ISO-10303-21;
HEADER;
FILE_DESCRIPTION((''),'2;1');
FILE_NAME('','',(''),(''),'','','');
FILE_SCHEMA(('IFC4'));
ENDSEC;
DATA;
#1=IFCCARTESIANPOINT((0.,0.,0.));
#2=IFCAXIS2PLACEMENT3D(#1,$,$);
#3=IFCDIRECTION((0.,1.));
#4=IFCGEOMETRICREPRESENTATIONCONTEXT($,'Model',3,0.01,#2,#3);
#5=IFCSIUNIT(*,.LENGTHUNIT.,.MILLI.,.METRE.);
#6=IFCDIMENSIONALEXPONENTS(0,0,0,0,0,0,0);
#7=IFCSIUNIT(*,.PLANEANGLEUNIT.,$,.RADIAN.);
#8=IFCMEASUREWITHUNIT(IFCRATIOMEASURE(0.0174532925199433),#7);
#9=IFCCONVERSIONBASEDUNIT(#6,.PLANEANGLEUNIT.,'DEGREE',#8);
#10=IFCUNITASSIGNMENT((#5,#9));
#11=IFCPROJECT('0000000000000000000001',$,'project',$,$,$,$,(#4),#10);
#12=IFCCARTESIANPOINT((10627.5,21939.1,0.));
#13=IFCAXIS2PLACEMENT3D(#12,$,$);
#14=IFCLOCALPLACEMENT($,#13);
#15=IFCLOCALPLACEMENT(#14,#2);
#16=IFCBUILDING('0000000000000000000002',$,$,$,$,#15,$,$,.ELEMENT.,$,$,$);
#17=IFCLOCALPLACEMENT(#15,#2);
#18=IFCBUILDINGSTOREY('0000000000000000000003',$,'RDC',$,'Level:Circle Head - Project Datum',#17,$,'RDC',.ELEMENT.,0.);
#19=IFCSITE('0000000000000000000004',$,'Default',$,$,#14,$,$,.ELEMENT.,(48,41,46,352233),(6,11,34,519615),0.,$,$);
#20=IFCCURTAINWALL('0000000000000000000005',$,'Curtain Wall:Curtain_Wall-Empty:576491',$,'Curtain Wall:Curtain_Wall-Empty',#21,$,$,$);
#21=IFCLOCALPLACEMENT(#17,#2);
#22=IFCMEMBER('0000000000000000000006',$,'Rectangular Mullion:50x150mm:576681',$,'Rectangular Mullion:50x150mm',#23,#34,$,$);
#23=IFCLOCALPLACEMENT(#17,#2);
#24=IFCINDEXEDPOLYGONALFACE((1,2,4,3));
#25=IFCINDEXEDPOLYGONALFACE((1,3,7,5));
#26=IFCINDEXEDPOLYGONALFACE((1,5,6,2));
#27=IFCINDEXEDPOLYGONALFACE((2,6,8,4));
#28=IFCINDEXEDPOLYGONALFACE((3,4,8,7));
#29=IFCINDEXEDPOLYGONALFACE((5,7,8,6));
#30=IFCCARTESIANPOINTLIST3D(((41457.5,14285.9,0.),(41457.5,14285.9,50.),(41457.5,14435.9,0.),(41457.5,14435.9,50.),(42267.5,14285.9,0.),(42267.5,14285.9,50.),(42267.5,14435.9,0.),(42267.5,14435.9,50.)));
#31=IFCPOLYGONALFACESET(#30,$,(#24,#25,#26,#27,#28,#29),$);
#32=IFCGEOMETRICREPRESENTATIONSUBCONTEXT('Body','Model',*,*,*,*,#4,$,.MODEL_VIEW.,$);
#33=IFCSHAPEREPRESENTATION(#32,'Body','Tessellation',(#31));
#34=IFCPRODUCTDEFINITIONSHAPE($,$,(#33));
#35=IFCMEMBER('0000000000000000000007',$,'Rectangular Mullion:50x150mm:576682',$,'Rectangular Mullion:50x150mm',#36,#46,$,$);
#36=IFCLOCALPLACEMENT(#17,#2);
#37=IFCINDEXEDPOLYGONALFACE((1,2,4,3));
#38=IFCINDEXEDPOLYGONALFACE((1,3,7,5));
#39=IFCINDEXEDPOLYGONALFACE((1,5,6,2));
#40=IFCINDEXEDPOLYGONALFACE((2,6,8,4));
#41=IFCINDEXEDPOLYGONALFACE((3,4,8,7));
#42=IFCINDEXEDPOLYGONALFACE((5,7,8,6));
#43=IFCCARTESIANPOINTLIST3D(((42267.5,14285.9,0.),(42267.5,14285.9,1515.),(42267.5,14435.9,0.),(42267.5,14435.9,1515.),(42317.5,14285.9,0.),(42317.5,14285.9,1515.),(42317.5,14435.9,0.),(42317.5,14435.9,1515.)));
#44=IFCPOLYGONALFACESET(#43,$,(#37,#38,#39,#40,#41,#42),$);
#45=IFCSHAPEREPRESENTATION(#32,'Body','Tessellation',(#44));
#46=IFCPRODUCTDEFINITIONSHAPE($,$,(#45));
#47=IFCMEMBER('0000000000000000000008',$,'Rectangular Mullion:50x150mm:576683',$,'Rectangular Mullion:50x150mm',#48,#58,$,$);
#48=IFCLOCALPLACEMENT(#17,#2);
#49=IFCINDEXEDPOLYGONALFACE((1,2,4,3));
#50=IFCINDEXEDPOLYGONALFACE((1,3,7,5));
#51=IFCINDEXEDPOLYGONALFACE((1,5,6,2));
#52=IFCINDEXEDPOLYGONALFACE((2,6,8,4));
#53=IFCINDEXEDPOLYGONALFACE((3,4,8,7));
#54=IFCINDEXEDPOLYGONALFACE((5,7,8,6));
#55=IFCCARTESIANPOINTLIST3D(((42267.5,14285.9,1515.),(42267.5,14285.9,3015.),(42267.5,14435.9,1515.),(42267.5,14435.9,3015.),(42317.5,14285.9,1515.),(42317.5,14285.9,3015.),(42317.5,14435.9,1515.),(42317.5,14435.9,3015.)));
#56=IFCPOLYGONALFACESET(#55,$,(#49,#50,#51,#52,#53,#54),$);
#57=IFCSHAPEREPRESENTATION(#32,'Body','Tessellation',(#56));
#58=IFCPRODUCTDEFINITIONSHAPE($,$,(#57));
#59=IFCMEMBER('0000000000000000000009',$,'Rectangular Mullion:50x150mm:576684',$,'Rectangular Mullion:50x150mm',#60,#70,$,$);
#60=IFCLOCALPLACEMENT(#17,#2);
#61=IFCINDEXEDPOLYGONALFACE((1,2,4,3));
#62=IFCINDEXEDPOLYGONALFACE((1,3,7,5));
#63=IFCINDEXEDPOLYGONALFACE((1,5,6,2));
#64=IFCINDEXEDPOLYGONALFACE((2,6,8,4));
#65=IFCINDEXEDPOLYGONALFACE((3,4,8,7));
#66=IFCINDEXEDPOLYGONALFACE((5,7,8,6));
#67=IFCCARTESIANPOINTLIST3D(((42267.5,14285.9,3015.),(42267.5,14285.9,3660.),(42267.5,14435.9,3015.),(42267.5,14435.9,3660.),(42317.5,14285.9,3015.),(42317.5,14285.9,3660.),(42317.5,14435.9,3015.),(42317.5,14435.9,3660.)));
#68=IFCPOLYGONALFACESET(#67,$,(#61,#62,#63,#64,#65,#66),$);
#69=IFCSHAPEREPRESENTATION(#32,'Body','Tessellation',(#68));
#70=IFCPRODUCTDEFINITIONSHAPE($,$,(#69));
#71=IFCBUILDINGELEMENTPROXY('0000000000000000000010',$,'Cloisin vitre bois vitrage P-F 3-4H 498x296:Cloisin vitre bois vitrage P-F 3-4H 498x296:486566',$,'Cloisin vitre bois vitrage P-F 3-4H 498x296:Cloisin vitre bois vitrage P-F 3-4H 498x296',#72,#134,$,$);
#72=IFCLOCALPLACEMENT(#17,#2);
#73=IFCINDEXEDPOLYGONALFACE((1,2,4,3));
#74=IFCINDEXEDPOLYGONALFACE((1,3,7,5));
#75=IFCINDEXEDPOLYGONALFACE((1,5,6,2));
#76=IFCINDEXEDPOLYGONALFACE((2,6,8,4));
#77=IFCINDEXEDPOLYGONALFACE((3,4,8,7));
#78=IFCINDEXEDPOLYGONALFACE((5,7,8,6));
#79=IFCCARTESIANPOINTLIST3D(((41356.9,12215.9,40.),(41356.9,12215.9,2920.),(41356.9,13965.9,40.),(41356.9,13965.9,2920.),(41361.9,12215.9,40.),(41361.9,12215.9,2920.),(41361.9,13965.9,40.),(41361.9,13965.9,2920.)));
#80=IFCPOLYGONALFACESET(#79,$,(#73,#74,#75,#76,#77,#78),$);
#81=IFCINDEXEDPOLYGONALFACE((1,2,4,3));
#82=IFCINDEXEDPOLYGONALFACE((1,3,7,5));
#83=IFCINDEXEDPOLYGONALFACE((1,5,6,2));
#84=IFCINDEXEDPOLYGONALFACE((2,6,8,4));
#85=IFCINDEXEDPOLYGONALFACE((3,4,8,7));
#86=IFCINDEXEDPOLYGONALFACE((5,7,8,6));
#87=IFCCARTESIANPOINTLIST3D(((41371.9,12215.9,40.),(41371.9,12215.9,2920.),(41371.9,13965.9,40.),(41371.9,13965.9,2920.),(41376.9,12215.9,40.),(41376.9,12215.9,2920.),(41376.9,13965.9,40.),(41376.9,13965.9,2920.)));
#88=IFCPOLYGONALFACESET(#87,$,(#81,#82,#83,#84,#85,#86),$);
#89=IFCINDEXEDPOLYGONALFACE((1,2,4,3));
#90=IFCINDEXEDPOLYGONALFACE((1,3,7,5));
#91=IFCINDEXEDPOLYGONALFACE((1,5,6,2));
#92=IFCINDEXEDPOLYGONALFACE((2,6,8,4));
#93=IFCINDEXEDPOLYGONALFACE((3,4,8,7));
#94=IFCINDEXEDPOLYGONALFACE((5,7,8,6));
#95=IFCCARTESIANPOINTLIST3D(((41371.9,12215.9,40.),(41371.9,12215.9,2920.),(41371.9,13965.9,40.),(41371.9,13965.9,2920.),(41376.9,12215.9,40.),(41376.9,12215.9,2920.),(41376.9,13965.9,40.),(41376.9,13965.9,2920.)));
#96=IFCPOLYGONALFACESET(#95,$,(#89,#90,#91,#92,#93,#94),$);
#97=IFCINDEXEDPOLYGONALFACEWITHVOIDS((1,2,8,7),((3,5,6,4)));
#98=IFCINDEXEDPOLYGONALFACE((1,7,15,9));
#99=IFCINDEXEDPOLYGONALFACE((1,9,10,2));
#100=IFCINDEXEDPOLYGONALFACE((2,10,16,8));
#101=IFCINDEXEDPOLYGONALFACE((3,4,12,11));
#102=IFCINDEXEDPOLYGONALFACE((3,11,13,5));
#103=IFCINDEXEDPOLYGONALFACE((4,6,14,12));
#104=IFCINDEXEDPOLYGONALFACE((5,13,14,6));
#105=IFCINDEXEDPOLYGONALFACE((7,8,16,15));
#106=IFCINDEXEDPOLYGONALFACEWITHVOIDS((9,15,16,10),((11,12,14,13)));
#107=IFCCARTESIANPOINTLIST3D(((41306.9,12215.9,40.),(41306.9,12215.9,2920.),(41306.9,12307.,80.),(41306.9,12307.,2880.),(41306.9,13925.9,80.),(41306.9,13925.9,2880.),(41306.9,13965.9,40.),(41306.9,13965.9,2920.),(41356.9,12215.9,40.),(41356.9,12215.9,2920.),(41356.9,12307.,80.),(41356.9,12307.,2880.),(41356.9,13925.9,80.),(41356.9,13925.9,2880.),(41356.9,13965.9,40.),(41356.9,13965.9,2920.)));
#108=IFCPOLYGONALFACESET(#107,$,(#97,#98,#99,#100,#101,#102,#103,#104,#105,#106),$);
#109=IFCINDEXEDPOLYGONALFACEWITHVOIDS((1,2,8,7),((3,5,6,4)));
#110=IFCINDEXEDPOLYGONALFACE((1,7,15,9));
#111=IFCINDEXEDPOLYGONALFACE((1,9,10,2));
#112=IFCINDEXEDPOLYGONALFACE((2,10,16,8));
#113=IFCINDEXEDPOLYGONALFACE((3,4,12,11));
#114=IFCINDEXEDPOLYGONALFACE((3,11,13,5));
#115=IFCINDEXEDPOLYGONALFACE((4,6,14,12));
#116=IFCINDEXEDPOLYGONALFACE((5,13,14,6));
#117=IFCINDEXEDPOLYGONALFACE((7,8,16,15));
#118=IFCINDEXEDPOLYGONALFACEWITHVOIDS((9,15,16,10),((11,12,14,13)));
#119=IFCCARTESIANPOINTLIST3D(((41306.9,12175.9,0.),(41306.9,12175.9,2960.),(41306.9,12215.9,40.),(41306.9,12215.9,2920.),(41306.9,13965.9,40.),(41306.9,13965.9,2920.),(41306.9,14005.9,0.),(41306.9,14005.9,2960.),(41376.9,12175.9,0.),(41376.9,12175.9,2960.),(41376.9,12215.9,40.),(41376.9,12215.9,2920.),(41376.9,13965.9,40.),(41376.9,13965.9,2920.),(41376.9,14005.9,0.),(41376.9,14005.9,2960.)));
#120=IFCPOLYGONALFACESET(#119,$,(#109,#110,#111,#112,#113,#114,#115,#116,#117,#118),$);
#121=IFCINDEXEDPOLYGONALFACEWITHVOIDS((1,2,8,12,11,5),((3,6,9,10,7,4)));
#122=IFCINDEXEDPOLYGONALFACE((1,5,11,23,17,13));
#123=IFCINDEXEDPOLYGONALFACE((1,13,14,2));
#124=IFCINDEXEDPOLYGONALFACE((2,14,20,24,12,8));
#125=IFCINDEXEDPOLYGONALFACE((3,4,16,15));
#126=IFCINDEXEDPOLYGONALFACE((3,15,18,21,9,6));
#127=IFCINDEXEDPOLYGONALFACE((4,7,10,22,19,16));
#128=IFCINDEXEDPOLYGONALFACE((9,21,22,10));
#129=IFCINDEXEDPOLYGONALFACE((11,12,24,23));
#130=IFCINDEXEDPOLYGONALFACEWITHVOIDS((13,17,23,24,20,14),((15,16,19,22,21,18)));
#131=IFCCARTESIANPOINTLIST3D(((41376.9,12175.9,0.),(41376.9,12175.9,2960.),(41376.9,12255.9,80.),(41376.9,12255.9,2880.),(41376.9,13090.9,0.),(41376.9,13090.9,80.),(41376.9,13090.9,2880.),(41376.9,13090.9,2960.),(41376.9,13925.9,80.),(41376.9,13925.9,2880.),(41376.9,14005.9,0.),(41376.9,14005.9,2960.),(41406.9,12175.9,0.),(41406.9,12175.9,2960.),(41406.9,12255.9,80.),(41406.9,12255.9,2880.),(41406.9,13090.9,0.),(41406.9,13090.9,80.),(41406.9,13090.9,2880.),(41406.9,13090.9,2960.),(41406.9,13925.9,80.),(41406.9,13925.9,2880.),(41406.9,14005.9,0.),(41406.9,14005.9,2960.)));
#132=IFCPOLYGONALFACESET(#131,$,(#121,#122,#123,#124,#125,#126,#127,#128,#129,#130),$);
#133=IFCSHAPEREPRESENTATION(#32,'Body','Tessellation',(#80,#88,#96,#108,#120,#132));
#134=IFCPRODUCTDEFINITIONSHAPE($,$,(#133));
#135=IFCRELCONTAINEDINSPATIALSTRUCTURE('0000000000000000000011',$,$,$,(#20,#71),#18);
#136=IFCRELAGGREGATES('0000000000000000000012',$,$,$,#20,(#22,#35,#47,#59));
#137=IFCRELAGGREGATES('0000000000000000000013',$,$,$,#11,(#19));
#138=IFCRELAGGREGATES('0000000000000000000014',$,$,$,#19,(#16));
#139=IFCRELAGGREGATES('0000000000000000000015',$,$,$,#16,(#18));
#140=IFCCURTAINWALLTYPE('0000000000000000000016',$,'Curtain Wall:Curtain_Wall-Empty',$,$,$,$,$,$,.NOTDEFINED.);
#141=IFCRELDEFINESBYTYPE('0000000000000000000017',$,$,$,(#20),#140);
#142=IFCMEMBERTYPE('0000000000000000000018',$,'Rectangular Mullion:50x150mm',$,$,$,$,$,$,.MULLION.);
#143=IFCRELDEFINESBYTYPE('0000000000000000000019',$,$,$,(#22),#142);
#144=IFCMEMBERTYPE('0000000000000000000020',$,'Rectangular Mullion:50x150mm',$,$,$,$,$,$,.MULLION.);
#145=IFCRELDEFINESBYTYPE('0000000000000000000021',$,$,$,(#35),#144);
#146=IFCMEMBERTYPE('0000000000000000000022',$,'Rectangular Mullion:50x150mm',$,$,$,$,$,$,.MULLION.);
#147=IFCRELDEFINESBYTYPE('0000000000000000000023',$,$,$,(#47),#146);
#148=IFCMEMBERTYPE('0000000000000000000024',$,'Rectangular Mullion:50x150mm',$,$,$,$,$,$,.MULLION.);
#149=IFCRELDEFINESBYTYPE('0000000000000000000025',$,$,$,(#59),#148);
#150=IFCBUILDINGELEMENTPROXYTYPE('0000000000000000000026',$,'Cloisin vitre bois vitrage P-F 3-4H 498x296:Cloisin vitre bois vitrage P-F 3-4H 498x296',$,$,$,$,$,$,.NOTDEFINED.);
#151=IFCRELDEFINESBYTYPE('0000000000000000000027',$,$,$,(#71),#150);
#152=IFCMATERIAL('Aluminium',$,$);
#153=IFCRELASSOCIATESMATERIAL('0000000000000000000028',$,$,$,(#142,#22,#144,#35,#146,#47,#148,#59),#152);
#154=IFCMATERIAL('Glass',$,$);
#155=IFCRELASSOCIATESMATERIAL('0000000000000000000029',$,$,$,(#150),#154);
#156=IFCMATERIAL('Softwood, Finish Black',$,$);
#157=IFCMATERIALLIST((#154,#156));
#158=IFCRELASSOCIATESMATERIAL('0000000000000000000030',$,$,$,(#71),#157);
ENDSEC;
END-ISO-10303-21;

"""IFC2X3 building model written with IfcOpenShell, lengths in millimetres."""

from ifc_helpers import new_model, entity, si_unit, converted_unit, direction, frame, frame_2d, origin, origin_2d_with_axis, place, context, subcontext, project, spatial, polyline, rectangle, outline, extrude, source, transform, mapped, material, material_list, type_object, type_shapes, element, aggregate, save


model = new_model("IFC2X3")

# Units and contexts
model_context = context("Model", 3, precision=0.01, world=origin(), true_north=direction((0.0, 1.0)))
body_context = subcontext(model_context, "Body", "Model", "MODEL_VIEW")
ifc_project = project(units=[si_unit("LENGTHUNIT", "METRE", prefix="MILLI"), converted_unit("PLANEANGLEUNIT", "DEGREE", entity("IfcRatioMeasure", 0.0174532925199433), si_unit("PLANEANGLEUNIT", "RADIAN"), dimensions=[0, 0, 0, 0, 0, 0, 0])], contexts=[model_context])

# Site, building, storey
site_placement = place(None, frame((10627.5, 21939.1, 0.0)))
site = spatial("IfcSite", under=ifc_project, at=site_placement, Name="Default", CompositionType="ELEMENT", RefLatitude=(48, 41, 46, 352233), RefLongitude=(6, 11, 34, 519615), RefElevation=0.0)
building_placement = place(site_placement, origin())
building = spatial("IfcBuilding", under=site, at=building_placement, CompositionType="ELEMENT")
storey_placement = place(building_placement, origin())
storey = spatial("IfcBuildingStorey", under=building, at=storey_placement, Name="RDC", ObjectType="Level:Circle Head - Project Datum", LongName="RDC", CompositionType="ELEMENT", Elevation=0.0)

# Curtain wall
curtain_wall_type = type_object("IfcCurtainWallType", Name="Curtain Wall:Curtain_Wall-Empty", PredefinedType="NOTDEFINED")
curtain_wall_1_placement = place(storey_placement, origin())
curtain_wall_1 = element("IfcCurtainWall", 1, at=curtain_wall_1_placement, inside=storey, type_object=curtain_wall_type, Name="Curtain Wall:Curtain_Wall-Empty:576491", ObjectType="Curtain Wall:Curtain_Wall-Empty")
ifc_material_1 = material(Name="Aluminium")

# Members
member_type_1 = type_object("IfcMemberType", Name="Rectangular Mullion:50x150mm", PredefinedType="MULLION", material=ifc_material_1)
shared_shape_1 = source(origin(), body_context, "Body", "SweptSolid", [
    extrude(rectangle(XDim=150.0, YDim=50.0, at=origin_2d_with_axis()), frame((-25.0, 0.0, -810.0), z_axis=(0.0, 0.0, 1.0), x_axis=(0.0, -1.0, 0.0)), (0.0, 0.0, 1.0), 810.0),
])
type_shapes(member_type_1, [shared_shape_1])
member_1_placement = place(storey_placement, frame((42267.5, 14360.9, 0.0), z_axis=(1.0, 0.0, 0.0), x_axis=(0.0, 0.0, -1.0)))
member_1 = element("IfcMember", 2, at=member_1_placement, type_object=member_type_1, material=ifc_material_1, Name="Rectangular Mullion:50x150mm:576681", ObjectType="Rectangular Mullion:50x150mm", context=body_context, shape_type="MappedRepresentation", body=[
    mapped(shared_shape_1, transform((0.0, 0.0, 0.0), scale=1.0)),
])
member_type_2 = type_object("IfcMemberType", Name="Rectangular Mullion:50x150mm", PredefinedType="MULLION", material=ifc_material_1)
shared_shape_2 = source(origin(), body_context, "Body", "SweptSolid", [
    extrude(rectangle(XDim=150.0, YDim=50.0, at=origin_2d_with_axis()), frame((0.0, 0.0, -1515.0), z_axis=(0.0, 0.0, 1.0), x_axis=(0.0, -1.0, 0.0)), (0.0, 0.0, 1.0), 1515.0),
])
type_shapes(member_type_2, [shared_shape_2])
member_2_placement = place(storey_placement, frame((42292.5, 14360.9, 0.0), z_axis=(0.0, 0.0, -1.0), x_axis=(-1.0, 0.0, 0.0)))
member_2 = element("IfcMember", 3, at=member_2_placement, type_object=member_type_2, material=ifc_material_1, Name="Rectangular Mullion:50x150mm:576682", ObjectType="Rectangular Mullion:50x150mm", context=body_context, shape_type="MappedRepresentation", body=[
    mapped(shared_shape_2, transform((0.0, 0.0, 0.0), scale=1.0)),
])
member_type_3 = type_object("IfcMemberType", Name="Rectangular Mullion:50x150mm", PredefinedType="MULLION", material=ifc_material_1)
shared_shape_3 = source(origin(), body_context, "Body", "SweptSolid", [
    extrude(rectangle(XDim=150.0, YDim=50.0, at=origin_2d_with_axis()), frame((0.0, 0.0, -1500.0), z_axis=(0.0, 0.0, 1.0), x_axis=(0.0, -1.0, 0.0)), (0.0, 0.0, 1.0), 1500.0),
])
type_shapes(member_type_3, [shared_shape_3])
member_3_placement = place(storey_placement, frame((42292.5, 14360.9, 1515.0), z_axis=(0.0, 0.0, -1.0), x_axis=(-1.0, 0.0, 0.0)))
member_3 = element("IfcMember", 4, at=member_3_placement, type_object=member_type_3, material=ifc_material_1, Name="Rectangular Mullion:50x150mm:576683", ObjectType="Rectangular Mullion:50x150mm", context=body_context, shape_type="MappedRepresentation", body=[
    mapped(shared_shape_3, transform((0.0, 0.0, 0.0), scale=1.0)),
])
member_type_4 = type_object("IfcMemberType", Name="Rectangular Mullion:50x150mm", PredefinedType="MULLION", material=ifc_material_1)
shared_shape_4 = source(origin(), body_context, "Body", "SweptSolid", [
    extrude(rectangle(XDim=150.0, YDim=50.0, at=origin_2d_with_axis()), frame((0.0, 0.0, -645.0), z_axis=(0.0, 0.0, 1.0), x_axis=(0.0, -1.0, 0.0)), (0.0, 0.0, 1.0), 645.0),
])
type_shapes(member_type_4, [shared_shape_4])
member_4_placement = place(storey_placement, frame((42292.5, 14360.9, 3015.0), z_axis=(0.0, 0.0, -1.0), x_axis=(-1.0, 0.0, 0.0)))
member_4 = element("IfcMember", 5, at=member_4_placement, type_object=member_type_4, material=ifc_material_1, Name="Rectangular Mullion:50x150mm:576684", ObjectType="Rectangular Mullion:50x150mm", context=body_context, shape_type="MappedRepresentation", body=[
    mapped(shared_shape_4, transform((0.0, 0.0, 0.0), scale=1.0)),
])

# Shared definitions
ifc_material_2 = material(Name="Glass")
aggregate(curtain_wall_1, [member_1, member_2, member_3, member_4])

# Building element proxy
ifc_material_3 = material(Name="Softwood, Finish Black")
ifc_material_list_1 = material_list([ifc_material_2, ifc_material_3])
building_element_proxy_type = type_object("IfcBuildingElementProxyType", Name="Cloisin vitre bois vitrage P-F 3-4H 498x296:Cloisin vitre bois vitrage P-F 3-4H 498x296", PredefinedType="NOTDEFINED", material=ifc_material_2)
shared_shape_5 = source(origin(), body_context, "Body", "SweptSolid", [
    extrude(rectangle(XDim=5.0, YDim=1750.0, at=frame_2d((0.0, 0.0), x_axis=(1.0, 0.0))), frame((0.0, -47.5, 40.0), z_axis=(0.0, 0.0, 1.0), x_axis=(0.0, 1.0, 0.0)), (0.0, 0.0, 1.0), 2880.0),
    extrude(rectangle(XDim=5.0, YDim=1750.0, at=frame_2d((0.0, 0.0), x_axis=(1.0, 0.0))), frame((0.0, -32.5, 40.0), z_axis=(0.0, 0.0, 1.0), x_axis=(0.0, 1.0, 0.0)), (0.0, 0.0, 1.0), 2880.0),
    extrude(rectangle(XDim=5.0, YDim=1750.0, at=frame_2d((0.0, 0.0), x_axis=(1.0, 0.0))), frame((0.0, -32.5, 40.0), z_axis=(0.0, 0.0, 1.0), x_axis=(0.0, 1.0, 0.0)), (0.0, 0.0, 1.0), 2880.0),
    extrude(outline(polyline([(-1440.0, -875.0), (1440.0, -875.0), (1440.0, 875.0), (-1440.0, 875.0), (-1440.0, -875.0)]), holes=[polyline([(1400.0, 835.0), (1400.0, -783.9), (-1400.0, -783.9), (-1400.0, 835.0), (1400.0, 835.0)])]), frame((0.0, -100.0, 1480.0), z_axis=(0.0, 1.0, 0.0), x_axis=(0.0, 0.0, -1.0)), (0.0, 0.0, 1.0), 50.0),
    extrude(outline(polyline([(-1480.0, -915.0), (1480.0, -915.0), (1480.0, 915.0), (-1480.0, 915.0), (-1480.0, -915.0)]), holes=[polyline([(-1440.0, -875.0), (-1440.0, 875.0), (1440.0, 875.0), (1440.0, -875.0), (-1440.0, -875.0)])]), frame((0.0, -100.0, 1480.0), z_axis=(0.0, 1.0, 0.0), x_axis=(0.0, 0.0, -1.0)), (0.0, 0.0, 1.0), 70.0),
    extrude(outline(polyline([(-1480.0, -915.0), (1480.0, -915.0), (1480.0, 0.0), (1480.0, 915.0), (-1480.0, 915.0), (-1480.0, 0.0), (-1480.0, -915.0)]), holes=[polyline([(1400.0, 0.0), (1400.0, -835.0), (-1400.0, -835.0), (-1400.0, 0.0), (-1400.0, 835.0), (1400.0, 835.0), (1400.0, 0.0)])]), frame((0.0, -30.0, 1480.0), z_axis=(0.0, 1.0, 0.0), x_axis=(0.0, 0.0, 1.0)), (0.0, 0.0, 1.0), 30.0),
])
type_shapes(building_element_proxy_type, [shared_shape_5])
proxy_1_placement = place(storey_placement, frame((41406.9, 13090.9, 0.0), z_axis=(0.0, 0.0, 1.0), x_axis=(0.0, -1.0, 0.0)))
element("IfcBuildingElementProxy", 6, at=proxy_1_placement, inside=storey, type_object=building_element_proxy_type, material=ifc_material_list_1, Name="Cloisin vitre bois vitrage P-F 3-4H 498x296:Cloisin vitre bois vitrage P-F 3-4H 498x296:486566", ObjectType="Cloisin vitre bois vitrage P-F 3-4H 498x296:Cloisin vitre bois vitrage P-F 3-4H 498x296", context=body_context, shape_type="MappedRepresentation", body=[
    mapped(shared_shape_5, transform((0.0, 0.0, 0.0), scale=1.0)),
])

save(model, "model.ifc")
